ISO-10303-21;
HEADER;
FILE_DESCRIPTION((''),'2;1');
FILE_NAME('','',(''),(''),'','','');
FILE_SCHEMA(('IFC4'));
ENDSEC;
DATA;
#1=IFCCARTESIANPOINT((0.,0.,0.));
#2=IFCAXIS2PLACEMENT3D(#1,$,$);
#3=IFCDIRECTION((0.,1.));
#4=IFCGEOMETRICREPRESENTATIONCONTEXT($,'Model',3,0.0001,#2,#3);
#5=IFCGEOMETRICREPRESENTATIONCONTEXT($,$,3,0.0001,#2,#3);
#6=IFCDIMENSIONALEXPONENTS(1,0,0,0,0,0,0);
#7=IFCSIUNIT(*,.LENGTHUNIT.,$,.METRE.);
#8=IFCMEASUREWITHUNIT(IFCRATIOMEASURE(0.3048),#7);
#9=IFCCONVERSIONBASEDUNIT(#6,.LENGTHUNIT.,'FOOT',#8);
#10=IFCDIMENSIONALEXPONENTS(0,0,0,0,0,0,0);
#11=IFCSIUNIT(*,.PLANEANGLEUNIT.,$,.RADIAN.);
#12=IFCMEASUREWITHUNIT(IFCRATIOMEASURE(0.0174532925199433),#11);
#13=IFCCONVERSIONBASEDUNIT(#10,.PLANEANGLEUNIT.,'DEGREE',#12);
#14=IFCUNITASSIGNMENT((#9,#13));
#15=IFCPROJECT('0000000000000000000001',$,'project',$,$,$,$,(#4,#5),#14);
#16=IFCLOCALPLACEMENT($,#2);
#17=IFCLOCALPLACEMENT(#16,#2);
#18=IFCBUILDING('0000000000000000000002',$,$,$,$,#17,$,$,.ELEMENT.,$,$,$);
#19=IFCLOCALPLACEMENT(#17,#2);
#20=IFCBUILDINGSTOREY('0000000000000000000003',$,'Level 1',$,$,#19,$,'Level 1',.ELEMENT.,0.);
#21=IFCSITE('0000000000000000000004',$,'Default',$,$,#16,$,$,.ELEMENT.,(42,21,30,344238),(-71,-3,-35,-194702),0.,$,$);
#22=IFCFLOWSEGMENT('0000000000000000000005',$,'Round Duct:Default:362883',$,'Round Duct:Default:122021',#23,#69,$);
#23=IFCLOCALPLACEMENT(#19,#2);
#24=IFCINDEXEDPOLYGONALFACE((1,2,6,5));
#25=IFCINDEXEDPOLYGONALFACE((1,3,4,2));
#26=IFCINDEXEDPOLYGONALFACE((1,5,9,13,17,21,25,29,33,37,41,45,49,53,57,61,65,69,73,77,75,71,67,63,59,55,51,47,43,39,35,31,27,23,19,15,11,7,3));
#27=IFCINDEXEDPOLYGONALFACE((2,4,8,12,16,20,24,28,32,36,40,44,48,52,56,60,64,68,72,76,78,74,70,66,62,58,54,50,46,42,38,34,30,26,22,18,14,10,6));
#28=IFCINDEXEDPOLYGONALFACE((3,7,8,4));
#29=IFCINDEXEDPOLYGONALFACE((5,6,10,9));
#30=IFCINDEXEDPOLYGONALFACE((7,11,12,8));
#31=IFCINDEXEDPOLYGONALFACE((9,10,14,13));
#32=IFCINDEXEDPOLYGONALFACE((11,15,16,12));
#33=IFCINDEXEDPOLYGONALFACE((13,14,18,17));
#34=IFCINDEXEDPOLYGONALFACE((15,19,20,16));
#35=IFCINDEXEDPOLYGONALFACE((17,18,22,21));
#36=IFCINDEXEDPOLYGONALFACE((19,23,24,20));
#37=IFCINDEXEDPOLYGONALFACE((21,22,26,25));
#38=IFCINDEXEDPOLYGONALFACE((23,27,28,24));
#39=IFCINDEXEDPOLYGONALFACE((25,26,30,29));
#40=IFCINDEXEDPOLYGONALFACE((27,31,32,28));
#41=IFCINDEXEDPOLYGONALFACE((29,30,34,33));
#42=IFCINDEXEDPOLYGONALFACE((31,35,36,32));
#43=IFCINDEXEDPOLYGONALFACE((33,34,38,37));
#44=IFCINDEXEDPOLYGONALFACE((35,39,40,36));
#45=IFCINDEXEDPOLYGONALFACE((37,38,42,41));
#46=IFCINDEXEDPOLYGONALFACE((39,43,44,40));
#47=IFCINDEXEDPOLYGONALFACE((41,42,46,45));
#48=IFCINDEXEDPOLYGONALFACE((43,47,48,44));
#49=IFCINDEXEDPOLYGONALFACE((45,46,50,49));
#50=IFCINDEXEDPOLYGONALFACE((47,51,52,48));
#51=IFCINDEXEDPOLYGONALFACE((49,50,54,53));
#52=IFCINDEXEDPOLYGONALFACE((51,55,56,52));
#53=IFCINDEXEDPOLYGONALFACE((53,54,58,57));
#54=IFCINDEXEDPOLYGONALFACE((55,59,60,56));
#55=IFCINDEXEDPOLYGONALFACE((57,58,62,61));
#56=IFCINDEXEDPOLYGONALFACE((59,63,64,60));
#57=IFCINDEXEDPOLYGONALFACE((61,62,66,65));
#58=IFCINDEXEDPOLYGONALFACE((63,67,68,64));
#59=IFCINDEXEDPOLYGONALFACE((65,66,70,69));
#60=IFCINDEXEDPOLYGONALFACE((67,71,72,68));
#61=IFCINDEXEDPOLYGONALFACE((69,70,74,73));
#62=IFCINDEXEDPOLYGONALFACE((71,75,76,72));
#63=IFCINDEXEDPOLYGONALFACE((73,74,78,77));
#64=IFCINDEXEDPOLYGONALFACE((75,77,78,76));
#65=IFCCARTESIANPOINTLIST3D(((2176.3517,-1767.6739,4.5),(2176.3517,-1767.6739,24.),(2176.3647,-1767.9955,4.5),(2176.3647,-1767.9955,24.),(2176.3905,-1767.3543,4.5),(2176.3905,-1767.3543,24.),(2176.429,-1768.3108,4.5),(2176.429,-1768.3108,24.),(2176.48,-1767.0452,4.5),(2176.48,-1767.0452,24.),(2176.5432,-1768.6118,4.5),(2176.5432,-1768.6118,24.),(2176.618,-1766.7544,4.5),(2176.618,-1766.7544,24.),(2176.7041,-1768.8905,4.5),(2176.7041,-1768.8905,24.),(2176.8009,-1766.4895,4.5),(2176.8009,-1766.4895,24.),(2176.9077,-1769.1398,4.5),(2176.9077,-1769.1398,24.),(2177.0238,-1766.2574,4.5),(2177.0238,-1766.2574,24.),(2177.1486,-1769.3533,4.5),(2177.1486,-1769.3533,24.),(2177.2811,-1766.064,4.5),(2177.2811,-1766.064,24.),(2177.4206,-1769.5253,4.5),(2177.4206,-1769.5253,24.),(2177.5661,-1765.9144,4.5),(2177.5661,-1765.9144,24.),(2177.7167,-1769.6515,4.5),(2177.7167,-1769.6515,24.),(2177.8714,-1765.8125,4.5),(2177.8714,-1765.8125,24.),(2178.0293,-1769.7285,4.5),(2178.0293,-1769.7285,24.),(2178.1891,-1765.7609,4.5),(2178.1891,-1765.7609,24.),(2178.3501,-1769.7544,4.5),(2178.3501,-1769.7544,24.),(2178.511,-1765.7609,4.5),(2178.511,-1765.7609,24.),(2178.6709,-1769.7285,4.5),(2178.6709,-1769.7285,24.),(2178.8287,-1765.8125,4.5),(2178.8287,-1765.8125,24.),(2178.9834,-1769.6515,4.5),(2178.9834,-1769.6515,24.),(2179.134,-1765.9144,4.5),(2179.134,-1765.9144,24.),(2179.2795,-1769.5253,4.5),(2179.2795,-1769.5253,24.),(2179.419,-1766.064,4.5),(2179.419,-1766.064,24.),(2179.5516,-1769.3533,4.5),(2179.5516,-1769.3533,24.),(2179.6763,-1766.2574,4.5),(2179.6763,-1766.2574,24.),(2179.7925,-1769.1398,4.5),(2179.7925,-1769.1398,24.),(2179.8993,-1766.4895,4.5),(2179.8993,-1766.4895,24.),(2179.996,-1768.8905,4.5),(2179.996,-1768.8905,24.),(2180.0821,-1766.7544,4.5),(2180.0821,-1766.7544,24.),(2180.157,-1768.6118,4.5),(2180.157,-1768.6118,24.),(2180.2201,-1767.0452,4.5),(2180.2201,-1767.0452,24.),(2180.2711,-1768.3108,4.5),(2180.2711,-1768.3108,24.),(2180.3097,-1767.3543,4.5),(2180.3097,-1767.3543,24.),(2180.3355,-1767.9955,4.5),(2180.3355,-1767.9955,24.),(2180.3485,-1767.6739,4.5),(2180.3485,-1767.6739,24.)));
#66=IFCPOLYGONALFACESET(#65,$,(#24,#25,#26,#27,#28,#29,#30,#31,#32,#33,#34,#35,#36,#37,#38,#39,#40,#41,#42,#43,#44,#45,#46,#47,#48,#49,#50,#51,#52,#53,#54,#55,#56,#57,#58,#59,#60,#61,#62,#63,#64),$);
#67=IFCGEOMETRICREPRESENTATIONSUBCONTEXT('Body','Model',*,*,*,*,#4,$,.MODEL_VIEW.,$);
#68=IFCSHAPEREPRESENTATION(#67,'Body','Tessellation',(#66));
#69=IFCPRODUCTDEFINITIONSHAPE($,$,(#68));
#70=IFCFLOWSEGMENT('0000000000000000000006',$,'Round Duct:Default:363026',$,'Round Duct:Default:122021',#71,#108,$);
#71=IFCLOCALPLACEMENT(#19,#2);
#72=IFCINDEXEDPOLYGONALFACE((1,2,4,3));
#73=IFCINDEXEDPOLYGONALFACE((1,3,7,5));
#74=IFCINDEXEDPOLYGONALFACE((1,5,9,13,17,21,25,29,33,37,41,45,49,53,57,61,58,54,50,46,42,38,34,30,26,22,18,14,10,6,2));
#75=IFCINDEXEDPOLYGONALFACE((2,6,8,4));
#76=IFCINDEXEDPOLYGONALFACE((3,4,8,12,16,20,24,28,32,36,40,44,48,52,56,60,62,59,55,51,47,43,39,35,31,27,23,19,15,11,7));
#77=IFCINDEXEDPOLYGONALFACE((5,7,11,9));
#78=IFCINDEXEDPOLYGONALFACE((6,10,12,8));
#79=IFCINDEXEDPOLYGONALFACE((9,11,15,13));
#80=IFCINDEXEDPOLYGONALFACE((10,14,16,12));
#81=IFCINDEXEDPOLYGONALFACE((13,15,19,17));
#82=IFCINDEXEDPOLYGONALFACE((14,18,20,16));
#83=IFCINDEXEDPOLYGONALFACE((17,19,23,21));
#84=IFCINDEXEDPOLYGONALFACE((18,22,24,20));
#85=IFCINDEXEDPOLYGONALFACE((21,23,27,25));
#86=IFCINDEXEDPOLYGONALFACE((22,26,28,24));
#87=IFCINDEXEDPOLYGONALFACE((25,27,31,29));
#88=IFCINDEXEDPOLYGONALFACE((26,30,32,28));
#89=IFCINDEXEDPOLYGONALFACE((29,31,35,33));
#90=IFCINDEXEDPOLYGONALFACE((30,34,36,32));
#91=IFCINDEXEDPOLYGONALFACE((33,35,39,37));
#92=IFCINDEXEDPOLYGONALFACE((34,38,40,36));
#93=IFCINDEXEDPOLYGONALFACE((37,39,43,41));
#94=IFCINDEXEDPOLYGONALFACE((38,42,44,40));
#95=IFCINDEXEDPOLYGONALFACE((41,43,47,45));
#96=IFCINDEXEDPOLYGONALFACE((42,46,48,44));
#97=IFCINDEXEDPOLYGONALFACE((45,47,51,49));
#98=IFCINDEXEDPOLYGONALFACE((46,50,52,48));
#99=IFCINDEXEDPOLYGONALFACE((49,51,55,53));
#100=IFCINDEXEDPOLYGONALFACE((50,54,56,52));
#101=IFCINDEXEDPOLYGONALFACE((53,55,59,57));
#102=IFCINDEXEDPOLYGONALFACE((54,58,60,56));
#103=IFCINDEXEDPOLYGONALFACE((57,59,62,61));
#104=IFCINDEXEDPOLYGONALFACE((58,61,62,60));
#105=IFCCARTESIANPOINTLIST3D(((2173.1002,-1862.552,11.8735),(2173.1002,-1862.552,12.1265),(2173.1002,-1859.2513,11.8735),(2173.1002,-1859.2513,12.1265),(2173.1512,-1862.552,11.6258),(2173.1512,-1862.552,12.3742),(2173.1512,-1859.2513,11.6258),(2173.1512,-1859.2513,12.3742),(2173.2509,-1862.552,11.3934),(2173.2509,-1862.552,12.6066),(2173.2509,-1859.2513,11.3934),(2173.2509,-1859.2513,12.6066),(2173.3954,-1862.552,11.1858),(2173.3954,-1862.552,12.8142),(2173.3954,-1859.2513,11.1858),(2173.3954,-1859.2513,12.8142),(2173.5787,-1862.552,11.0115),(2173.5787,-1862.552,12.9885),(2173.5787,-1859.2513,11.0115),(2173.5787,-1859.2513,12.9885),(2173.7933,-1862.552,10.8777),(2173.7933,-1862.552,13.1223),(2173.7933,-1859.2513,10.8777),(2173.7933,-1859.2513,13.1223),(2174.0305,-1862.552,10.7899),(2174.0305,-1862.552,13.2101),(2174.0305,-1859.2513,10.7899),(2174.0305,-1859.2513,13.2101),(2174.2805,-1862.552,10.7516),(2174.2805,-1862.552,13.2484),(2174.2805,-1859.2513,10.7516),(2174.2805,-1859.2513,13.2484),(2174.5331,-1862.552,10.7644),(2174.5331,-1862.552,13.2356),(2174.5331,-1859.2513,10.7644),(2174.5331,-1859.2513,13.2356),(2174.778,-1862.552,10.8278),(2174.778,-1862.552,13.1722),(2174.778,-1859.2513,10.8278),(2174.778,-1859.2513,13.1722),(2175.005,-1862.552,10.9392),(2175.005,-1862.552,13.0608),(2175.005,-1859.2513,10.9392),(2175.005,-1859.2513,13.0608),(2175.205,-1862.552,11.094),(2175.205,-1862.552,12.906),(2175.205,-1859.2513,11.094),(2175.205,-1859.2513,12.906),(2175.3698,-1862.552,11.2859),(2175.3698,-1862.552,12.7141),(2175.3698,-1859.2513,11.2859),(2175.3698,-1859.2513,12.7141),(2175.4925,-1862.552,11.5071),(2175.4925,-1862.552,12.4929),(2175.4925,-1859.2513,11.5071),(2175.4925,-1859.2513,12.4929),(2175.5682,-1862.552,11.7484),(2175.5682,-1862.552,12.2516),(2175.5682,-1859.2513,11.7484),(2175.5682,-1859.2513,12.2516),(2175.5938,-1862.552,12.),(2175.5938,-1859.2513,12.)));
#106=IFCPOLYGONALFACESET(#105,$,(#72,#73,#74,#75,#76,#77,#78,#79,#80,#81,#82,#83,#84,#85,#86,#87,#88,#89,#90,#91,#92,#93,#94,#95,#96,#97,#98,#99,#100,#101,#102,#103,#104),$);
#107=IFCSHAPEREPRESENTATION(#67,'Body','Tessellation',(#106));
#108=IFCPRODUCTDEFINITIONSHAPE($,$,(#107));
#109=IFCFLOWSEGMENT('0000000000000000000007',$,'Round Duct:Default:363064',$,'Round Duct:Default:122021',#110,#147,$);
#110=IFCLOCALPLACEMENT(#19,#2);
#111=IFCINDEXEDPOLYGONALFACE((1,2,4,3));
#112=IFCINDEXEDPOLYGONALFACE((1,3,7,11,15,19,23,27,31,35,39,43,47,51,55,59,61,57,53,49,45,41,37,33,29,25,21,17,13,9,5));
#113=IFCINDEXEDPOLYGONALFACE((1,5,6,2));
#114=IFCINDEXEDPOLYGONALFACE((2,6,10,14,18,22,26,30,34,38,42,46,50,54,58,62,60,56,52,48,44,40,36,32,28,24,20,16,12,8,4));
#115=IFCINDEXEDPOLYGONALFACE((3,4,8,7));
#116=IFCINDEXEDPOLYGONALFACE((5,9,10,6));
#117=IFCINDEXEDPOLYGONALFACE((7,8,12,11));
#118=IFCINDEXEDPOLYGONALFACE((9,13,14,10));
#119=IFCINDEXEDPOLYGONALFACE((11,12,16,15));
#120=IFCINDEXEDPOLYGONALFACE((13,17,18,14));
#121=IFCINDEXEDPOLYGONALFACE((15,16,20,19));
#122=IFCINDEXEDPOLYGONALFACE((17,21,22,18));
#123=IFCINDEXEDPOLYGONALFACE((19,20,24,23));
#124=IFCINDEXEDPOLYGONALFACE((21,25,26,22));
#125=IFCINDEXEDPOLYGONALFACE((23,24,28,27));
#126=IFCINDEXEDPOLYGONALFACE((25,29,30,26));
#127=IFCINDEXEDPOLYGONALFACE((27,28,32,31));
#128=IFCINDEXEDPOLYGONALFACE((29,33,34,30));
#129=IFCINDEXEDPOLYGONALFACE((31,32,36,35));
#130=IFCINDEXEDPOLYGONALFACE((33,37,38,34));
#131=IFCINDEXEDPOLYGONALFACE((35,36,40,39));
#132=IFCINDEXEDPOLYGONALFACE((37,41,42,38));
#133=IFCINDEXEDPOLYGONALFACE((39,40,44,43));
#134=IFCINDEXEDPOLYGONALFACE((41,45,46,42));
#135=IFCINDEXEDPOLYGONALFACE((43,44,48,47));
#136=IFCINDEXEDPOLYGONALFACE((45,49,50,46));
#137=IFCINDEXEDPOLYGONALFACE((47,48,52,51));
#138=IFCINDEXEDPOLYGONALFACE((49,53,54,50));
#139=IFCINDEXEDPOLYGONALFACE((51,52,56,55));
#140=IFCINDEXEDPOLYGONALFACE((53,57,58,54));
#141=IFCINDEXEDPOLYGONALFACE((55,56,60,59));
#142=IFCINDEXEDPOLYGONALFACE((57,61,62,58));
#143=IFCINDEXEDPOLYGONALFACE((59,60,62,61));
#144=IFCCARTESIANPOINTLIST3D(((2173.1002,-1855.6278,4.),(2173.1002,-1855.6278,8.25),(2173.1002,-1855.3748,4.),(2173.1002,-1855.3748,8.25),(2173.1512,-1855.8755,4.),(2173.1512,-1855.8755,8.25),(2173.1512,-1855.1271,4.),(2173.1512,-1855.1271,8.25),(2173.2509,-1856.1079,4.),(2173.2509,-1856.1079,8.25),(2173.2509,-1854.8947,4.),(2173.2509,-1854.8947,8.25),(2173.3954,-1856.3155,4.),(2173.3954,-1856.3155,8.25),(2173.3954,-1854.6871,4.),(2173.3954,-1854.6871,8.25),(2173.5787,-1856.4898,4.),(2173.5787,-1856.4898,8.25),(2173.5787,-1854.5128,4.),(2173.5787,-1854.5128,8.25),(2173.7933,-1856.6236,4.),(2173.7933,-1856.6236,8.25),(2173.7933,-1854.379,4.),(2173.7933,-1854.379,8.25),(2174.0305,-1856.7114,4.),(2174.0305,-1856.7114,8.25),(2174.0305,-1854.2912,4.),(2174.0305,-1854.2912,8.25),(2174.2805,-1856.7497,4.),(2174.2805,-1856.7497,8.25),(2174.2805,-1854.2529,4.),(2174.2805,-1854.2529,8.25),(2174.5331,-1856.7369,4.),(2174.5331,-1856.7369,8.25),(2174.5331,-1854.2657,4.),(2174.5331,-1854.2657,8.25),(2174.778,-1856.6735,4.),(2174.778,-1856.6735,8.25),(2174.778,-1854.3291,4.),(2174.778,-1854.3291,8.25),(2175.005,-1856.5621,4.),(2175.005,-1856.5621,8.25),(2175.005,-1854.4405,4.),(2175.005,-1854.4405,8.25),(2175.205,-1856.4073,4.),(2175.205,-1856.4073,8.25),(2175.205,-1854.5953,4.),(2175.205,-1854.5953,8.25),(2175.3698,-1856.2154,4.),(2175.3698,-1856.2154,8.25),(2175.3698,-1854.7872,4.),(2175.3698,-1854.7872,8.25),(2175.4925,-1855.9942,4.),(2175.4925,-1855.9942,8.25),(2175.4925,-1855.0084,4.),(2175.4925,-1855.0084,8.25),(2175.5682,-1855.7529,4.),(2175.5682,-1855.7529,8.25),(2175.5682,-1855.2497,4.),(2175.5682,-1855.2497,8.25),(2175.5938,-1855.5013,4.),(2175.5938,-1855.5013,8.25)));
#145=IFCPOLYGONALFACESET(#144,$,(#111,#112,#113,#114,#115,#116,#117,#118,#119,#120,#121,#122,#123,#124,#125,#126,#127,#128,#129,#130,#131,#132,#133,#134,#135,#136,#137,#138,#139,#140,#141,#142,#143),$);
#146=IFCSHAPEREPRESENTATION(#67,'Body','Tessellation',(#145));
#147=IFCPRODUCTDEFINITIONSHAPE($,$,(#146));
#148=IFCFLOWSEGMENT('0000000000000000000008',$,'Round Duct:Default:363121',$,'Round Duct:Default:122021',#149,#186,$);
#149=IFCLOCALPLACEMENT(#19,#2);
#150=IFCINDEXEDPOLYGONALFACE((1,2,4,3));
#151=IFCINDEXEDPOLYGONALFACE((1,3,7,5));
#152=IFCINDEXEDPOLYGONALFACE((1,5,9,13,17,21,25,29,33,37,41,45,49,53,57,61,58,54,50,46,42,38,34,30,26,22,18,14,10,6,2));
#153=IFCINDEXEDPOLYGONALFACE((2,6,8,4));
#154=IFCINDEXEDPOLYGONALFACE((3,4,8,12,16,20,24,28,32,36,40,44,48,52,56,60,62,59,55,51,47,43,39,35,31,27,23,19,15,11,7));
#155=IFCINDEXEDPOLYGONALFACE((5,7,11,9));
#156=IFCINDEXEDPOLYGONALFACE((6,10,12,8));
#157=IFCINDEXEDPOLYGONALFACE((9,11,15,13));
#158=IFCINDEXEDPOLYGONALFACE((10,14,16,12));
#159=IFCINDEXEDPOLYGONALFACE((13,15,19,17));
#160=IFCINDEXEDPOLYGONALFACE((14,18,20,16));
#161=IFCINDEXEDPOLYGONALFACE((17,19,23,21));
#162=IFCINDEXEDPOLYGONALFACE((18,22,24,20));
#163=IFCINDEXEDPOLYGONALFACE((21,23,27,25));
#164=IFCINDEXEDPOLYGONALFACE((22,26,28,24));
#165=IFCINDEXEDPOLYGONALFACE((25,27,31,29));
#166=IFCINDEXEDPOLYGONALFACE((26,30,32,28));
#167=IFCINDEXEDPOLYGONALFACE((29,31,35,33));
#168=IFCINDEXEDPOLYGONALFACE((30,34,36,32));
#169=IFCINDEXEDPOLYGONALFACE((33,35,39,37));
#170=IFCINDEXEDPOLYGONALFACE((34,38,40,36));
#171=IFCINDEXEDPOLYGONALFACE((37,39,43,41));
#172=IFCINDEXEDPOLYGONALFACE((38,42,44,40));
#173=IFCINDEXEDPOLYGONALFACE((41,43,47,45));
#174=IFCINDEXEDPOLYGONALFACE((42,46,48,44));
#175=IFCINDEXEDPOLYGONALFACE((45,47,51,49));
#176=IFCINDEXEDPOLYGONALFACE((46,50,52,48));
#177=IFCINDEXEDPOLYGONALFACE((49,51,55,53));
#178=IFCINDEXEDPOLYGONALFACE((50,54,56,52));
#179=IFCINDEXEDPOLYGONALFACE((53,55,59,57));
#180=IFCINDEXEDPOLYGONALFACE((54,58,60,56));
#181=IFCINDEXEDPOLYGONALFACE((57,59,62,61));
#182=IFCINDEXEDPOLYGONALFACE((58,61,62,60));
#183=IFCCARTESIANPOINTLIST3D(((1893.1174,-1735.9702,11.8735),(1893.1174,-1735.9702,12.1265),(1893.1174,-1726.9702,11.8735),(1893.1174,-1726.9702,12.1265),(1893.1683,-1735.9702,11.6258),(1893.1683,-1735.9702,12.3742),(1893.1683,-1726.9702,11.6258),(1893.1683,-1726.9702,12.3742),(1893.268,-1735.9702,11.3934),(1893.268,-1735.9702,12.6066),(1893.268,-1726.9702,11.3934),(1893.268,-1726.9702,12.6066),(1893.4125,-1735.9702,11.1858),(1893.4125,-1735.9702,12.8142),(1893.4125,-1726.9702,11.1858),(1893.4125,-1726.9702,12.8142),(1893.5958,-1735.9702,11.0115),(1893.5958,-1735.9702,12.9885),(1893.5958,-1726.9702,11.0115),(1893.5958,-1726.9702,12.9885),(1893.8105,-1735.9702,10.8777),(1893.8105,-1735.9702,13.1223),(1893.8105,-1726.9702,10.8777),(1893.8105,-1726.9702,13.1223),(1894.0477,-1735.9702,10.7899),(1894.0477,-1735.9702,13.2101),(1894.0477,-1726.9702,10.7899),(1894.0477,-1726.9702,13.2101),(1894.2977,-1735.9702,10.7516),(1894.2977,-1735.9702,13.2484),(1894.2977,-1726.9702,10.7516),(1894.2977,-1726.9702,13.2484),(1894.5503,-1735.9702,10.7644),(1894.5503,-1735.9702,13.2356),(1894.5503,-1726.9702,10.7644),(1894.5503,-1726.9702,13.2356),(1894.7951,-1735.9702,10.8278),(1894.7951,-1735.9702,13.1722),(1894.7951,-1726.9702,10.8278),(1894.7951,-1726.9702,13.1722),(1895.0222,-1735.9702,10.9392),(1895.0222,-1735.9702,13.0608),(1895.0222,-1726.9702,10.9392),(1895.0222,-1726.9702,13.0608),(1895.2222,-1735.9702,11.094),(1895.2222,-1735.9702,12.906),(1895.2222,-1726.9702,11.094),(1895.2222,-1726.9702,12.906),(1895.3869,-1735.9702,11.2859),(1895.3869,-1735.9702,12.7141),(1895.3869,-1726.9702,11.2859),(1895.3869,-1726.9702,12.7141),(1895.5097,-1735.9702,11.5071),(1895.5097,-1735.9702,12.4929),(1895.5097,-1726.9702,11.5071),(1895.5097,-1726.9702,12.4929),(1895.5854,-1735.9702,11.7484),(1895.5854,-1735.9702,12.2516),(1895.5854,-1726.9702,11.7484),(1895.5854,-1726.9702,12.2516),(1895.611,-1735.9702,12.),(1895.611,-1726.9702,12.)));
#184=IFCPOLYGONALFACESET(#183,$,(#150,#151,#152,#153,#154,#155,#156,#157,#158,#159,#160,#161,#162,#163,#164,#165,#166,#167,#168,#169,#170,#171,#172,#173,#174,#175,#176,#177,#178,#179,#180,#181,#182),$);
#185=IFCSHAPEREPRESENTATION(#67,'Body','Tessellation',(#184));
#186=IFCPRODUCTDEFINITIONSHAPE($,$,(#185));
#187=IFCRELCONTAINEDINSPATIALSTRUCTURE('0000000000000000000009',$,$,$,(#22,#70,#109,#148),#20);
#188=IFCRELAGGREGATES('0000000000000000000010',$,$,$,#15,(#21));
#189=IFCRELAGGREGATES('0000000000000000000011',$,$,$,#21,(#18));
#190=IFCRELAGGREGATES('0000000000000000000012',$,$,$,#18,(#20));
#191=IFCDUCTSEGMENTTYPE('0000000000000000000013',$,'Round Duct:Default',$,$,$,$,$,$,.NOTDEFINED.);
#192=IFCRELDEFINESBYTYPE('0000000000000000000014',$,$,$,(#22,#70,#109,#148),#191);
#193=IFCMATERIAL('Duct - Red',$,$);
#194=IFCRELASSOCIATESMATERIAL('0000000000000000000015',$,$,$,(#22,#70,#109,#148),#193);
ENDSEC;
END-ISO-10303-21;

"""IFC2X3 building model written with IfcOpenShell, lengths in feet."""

from ifc_helpers import new_model, entity, si_unit, converted_unit, direction, frame, frame_2d, origin, origin_2d_with_axis, place, context, subcontext, project, spatial, circle, extrude, material, type_object, element, save


model = new_model("IFC2X3")

# Units and contexts
model_context = context("Model", 3, precision=0.0001, world=origin(), true_north=direction((0.0, 1.0)))
context_of_model = context(None, 3, precision=0.0001, world=origin(), true_north=direction((0.0, 1.0)))
body_context = subcontext(model_context, "Body", "Model", "MODEL_VIEW")
ifc_project = project(units=[converted_unit("LENGTHUNIT", "FOOT", entity("IfcRatioMeasure", 0.3048), si_unit("LENGTHUNIT", "METRE"), dimensions=[1, 0, 0, 0, 0, 0, 0]), converted_unit("PLANEANGLEUNIT", "DEGREE", entity("IfcRatioMeasure", 0.0174532925199433), si_unit("PLANEANGLEUNIT", "RADIAN"), dimensions=[0, 0, 0, 0, 0, 0, 0])], contexts=[model_context, context_of_model])

# Site, building, storey
site_placement = place(None, origin())
site = spatial("IfcSite", under=ifc_project, at=site_placement, Name="Default", CompositionType="ELEMENT", RefLatitude=(42, 21, 30, 344238), RefLongitude=(-71, -3, -35, -194702), RefElevation=0.0)
building_placement = place(site_placement, origin())
building = spatial("IfcBuilding", under=site, at=building_placement, CompositionType="ELEMENT")
storey_placement = place(building_placement, origin())
storey = spatial("IfcBuildingStorey", under=building, at=storey_placement, Name="Level 1", LongName="Level 1", CompositionType="ELEMENT", Elevation=0.0)

# Flow segments
ifc_material_1 = material(Name="Duct - Red")
duct_segment_type = type_object("IfcDuctSegmentType", Name="Round Duct:Default", PredefinedType="NOTDEFINED")
flow_segment_1_placement = place(storey_placement, origin())
element("IfcFlowSegment", 1, at=flow_segment_1_placement, inside=storey, type_object=duct_segment_type, material=ifc_material_1, Name="Round Duct:Default:362883", ObjectType="Round Duct:Default:122021", context=body_context, shape_type="SweptSolid", body=[
    extrude(circle(Radius=2.0, at=frame_2d((0.0, 0.0), x_axis=(1.0, 0.0))), frame((2178.3501, -1767.7544, 4.5), z_axis=(0.0, 0.0, 1.0), x_axis=(0.0, -1.0, 0.0)), (0.0, 0.0, 1.0), 19.5),
])
flow_segment_2_placement = place(storey_placement, origin())
element("IfcFlowSegment", 2, at=flow_segment_2_placement, inside=storey, type_object=duct_segment_type, material=ifc_material_1, Name="Round Duct:Default:363026", ObjectType="Round Duct:Default:122021", context=body_context, shape_type="SweptSolid", body=[
    extrude(circle(Radius=1.25, at=frame_2d((0.0, 0.0), x_axis=(1.0, 0.0))), frame((2174.3438, -1862.552, 12.0), z_axis=(0.0, 1.0, 0.0), x_axis=(1.0, 0.0, 0.0)), (0.0, 0.0, 1.0), 3.3007),
])
flow_segment_3_placement = place(storey_placement, origin())
element("IfcFlowSegment", 3, at=flow_segment_3_placement, inside=storey, type_object=duct_segment_type, material=ifc_material_1, Name="Round Duct:Default:363064", ObjectType="Round Duct:Default:122021", context=body_context, shape_type="SweptSolid", body=[
    extrude(circle(Radius=1.25, at=origin_2d_with_axis()), frame((2174.3438, -1855.5013, 4.0)), (0.0, 0.0, 1.0), 4.25),
])
flow_segment_4_placement = place(storey_placement, origin())
element("IfcFlowSegment", 4, at=flow_segment_4_placement, inside=storey, type_object=duct_segment_type, material=ifc_material_1, Name="Round Duct:Default:363121", ObjectType="Round Duct:Default:122021", context=body_context, shape_type="SweptSolid", body=[
    extrude(circle(Radius=1.25, at=origin_2d_with_axis()), frame((1894.361, -1735.9702, 12.0), z_axis=(0.0, 1.0, 0.0), x_axis=(1.0, 0.0, 0.0)), (0.0, 0.0, 1.0), 9.0),
])

save(model, "model.ifc")
